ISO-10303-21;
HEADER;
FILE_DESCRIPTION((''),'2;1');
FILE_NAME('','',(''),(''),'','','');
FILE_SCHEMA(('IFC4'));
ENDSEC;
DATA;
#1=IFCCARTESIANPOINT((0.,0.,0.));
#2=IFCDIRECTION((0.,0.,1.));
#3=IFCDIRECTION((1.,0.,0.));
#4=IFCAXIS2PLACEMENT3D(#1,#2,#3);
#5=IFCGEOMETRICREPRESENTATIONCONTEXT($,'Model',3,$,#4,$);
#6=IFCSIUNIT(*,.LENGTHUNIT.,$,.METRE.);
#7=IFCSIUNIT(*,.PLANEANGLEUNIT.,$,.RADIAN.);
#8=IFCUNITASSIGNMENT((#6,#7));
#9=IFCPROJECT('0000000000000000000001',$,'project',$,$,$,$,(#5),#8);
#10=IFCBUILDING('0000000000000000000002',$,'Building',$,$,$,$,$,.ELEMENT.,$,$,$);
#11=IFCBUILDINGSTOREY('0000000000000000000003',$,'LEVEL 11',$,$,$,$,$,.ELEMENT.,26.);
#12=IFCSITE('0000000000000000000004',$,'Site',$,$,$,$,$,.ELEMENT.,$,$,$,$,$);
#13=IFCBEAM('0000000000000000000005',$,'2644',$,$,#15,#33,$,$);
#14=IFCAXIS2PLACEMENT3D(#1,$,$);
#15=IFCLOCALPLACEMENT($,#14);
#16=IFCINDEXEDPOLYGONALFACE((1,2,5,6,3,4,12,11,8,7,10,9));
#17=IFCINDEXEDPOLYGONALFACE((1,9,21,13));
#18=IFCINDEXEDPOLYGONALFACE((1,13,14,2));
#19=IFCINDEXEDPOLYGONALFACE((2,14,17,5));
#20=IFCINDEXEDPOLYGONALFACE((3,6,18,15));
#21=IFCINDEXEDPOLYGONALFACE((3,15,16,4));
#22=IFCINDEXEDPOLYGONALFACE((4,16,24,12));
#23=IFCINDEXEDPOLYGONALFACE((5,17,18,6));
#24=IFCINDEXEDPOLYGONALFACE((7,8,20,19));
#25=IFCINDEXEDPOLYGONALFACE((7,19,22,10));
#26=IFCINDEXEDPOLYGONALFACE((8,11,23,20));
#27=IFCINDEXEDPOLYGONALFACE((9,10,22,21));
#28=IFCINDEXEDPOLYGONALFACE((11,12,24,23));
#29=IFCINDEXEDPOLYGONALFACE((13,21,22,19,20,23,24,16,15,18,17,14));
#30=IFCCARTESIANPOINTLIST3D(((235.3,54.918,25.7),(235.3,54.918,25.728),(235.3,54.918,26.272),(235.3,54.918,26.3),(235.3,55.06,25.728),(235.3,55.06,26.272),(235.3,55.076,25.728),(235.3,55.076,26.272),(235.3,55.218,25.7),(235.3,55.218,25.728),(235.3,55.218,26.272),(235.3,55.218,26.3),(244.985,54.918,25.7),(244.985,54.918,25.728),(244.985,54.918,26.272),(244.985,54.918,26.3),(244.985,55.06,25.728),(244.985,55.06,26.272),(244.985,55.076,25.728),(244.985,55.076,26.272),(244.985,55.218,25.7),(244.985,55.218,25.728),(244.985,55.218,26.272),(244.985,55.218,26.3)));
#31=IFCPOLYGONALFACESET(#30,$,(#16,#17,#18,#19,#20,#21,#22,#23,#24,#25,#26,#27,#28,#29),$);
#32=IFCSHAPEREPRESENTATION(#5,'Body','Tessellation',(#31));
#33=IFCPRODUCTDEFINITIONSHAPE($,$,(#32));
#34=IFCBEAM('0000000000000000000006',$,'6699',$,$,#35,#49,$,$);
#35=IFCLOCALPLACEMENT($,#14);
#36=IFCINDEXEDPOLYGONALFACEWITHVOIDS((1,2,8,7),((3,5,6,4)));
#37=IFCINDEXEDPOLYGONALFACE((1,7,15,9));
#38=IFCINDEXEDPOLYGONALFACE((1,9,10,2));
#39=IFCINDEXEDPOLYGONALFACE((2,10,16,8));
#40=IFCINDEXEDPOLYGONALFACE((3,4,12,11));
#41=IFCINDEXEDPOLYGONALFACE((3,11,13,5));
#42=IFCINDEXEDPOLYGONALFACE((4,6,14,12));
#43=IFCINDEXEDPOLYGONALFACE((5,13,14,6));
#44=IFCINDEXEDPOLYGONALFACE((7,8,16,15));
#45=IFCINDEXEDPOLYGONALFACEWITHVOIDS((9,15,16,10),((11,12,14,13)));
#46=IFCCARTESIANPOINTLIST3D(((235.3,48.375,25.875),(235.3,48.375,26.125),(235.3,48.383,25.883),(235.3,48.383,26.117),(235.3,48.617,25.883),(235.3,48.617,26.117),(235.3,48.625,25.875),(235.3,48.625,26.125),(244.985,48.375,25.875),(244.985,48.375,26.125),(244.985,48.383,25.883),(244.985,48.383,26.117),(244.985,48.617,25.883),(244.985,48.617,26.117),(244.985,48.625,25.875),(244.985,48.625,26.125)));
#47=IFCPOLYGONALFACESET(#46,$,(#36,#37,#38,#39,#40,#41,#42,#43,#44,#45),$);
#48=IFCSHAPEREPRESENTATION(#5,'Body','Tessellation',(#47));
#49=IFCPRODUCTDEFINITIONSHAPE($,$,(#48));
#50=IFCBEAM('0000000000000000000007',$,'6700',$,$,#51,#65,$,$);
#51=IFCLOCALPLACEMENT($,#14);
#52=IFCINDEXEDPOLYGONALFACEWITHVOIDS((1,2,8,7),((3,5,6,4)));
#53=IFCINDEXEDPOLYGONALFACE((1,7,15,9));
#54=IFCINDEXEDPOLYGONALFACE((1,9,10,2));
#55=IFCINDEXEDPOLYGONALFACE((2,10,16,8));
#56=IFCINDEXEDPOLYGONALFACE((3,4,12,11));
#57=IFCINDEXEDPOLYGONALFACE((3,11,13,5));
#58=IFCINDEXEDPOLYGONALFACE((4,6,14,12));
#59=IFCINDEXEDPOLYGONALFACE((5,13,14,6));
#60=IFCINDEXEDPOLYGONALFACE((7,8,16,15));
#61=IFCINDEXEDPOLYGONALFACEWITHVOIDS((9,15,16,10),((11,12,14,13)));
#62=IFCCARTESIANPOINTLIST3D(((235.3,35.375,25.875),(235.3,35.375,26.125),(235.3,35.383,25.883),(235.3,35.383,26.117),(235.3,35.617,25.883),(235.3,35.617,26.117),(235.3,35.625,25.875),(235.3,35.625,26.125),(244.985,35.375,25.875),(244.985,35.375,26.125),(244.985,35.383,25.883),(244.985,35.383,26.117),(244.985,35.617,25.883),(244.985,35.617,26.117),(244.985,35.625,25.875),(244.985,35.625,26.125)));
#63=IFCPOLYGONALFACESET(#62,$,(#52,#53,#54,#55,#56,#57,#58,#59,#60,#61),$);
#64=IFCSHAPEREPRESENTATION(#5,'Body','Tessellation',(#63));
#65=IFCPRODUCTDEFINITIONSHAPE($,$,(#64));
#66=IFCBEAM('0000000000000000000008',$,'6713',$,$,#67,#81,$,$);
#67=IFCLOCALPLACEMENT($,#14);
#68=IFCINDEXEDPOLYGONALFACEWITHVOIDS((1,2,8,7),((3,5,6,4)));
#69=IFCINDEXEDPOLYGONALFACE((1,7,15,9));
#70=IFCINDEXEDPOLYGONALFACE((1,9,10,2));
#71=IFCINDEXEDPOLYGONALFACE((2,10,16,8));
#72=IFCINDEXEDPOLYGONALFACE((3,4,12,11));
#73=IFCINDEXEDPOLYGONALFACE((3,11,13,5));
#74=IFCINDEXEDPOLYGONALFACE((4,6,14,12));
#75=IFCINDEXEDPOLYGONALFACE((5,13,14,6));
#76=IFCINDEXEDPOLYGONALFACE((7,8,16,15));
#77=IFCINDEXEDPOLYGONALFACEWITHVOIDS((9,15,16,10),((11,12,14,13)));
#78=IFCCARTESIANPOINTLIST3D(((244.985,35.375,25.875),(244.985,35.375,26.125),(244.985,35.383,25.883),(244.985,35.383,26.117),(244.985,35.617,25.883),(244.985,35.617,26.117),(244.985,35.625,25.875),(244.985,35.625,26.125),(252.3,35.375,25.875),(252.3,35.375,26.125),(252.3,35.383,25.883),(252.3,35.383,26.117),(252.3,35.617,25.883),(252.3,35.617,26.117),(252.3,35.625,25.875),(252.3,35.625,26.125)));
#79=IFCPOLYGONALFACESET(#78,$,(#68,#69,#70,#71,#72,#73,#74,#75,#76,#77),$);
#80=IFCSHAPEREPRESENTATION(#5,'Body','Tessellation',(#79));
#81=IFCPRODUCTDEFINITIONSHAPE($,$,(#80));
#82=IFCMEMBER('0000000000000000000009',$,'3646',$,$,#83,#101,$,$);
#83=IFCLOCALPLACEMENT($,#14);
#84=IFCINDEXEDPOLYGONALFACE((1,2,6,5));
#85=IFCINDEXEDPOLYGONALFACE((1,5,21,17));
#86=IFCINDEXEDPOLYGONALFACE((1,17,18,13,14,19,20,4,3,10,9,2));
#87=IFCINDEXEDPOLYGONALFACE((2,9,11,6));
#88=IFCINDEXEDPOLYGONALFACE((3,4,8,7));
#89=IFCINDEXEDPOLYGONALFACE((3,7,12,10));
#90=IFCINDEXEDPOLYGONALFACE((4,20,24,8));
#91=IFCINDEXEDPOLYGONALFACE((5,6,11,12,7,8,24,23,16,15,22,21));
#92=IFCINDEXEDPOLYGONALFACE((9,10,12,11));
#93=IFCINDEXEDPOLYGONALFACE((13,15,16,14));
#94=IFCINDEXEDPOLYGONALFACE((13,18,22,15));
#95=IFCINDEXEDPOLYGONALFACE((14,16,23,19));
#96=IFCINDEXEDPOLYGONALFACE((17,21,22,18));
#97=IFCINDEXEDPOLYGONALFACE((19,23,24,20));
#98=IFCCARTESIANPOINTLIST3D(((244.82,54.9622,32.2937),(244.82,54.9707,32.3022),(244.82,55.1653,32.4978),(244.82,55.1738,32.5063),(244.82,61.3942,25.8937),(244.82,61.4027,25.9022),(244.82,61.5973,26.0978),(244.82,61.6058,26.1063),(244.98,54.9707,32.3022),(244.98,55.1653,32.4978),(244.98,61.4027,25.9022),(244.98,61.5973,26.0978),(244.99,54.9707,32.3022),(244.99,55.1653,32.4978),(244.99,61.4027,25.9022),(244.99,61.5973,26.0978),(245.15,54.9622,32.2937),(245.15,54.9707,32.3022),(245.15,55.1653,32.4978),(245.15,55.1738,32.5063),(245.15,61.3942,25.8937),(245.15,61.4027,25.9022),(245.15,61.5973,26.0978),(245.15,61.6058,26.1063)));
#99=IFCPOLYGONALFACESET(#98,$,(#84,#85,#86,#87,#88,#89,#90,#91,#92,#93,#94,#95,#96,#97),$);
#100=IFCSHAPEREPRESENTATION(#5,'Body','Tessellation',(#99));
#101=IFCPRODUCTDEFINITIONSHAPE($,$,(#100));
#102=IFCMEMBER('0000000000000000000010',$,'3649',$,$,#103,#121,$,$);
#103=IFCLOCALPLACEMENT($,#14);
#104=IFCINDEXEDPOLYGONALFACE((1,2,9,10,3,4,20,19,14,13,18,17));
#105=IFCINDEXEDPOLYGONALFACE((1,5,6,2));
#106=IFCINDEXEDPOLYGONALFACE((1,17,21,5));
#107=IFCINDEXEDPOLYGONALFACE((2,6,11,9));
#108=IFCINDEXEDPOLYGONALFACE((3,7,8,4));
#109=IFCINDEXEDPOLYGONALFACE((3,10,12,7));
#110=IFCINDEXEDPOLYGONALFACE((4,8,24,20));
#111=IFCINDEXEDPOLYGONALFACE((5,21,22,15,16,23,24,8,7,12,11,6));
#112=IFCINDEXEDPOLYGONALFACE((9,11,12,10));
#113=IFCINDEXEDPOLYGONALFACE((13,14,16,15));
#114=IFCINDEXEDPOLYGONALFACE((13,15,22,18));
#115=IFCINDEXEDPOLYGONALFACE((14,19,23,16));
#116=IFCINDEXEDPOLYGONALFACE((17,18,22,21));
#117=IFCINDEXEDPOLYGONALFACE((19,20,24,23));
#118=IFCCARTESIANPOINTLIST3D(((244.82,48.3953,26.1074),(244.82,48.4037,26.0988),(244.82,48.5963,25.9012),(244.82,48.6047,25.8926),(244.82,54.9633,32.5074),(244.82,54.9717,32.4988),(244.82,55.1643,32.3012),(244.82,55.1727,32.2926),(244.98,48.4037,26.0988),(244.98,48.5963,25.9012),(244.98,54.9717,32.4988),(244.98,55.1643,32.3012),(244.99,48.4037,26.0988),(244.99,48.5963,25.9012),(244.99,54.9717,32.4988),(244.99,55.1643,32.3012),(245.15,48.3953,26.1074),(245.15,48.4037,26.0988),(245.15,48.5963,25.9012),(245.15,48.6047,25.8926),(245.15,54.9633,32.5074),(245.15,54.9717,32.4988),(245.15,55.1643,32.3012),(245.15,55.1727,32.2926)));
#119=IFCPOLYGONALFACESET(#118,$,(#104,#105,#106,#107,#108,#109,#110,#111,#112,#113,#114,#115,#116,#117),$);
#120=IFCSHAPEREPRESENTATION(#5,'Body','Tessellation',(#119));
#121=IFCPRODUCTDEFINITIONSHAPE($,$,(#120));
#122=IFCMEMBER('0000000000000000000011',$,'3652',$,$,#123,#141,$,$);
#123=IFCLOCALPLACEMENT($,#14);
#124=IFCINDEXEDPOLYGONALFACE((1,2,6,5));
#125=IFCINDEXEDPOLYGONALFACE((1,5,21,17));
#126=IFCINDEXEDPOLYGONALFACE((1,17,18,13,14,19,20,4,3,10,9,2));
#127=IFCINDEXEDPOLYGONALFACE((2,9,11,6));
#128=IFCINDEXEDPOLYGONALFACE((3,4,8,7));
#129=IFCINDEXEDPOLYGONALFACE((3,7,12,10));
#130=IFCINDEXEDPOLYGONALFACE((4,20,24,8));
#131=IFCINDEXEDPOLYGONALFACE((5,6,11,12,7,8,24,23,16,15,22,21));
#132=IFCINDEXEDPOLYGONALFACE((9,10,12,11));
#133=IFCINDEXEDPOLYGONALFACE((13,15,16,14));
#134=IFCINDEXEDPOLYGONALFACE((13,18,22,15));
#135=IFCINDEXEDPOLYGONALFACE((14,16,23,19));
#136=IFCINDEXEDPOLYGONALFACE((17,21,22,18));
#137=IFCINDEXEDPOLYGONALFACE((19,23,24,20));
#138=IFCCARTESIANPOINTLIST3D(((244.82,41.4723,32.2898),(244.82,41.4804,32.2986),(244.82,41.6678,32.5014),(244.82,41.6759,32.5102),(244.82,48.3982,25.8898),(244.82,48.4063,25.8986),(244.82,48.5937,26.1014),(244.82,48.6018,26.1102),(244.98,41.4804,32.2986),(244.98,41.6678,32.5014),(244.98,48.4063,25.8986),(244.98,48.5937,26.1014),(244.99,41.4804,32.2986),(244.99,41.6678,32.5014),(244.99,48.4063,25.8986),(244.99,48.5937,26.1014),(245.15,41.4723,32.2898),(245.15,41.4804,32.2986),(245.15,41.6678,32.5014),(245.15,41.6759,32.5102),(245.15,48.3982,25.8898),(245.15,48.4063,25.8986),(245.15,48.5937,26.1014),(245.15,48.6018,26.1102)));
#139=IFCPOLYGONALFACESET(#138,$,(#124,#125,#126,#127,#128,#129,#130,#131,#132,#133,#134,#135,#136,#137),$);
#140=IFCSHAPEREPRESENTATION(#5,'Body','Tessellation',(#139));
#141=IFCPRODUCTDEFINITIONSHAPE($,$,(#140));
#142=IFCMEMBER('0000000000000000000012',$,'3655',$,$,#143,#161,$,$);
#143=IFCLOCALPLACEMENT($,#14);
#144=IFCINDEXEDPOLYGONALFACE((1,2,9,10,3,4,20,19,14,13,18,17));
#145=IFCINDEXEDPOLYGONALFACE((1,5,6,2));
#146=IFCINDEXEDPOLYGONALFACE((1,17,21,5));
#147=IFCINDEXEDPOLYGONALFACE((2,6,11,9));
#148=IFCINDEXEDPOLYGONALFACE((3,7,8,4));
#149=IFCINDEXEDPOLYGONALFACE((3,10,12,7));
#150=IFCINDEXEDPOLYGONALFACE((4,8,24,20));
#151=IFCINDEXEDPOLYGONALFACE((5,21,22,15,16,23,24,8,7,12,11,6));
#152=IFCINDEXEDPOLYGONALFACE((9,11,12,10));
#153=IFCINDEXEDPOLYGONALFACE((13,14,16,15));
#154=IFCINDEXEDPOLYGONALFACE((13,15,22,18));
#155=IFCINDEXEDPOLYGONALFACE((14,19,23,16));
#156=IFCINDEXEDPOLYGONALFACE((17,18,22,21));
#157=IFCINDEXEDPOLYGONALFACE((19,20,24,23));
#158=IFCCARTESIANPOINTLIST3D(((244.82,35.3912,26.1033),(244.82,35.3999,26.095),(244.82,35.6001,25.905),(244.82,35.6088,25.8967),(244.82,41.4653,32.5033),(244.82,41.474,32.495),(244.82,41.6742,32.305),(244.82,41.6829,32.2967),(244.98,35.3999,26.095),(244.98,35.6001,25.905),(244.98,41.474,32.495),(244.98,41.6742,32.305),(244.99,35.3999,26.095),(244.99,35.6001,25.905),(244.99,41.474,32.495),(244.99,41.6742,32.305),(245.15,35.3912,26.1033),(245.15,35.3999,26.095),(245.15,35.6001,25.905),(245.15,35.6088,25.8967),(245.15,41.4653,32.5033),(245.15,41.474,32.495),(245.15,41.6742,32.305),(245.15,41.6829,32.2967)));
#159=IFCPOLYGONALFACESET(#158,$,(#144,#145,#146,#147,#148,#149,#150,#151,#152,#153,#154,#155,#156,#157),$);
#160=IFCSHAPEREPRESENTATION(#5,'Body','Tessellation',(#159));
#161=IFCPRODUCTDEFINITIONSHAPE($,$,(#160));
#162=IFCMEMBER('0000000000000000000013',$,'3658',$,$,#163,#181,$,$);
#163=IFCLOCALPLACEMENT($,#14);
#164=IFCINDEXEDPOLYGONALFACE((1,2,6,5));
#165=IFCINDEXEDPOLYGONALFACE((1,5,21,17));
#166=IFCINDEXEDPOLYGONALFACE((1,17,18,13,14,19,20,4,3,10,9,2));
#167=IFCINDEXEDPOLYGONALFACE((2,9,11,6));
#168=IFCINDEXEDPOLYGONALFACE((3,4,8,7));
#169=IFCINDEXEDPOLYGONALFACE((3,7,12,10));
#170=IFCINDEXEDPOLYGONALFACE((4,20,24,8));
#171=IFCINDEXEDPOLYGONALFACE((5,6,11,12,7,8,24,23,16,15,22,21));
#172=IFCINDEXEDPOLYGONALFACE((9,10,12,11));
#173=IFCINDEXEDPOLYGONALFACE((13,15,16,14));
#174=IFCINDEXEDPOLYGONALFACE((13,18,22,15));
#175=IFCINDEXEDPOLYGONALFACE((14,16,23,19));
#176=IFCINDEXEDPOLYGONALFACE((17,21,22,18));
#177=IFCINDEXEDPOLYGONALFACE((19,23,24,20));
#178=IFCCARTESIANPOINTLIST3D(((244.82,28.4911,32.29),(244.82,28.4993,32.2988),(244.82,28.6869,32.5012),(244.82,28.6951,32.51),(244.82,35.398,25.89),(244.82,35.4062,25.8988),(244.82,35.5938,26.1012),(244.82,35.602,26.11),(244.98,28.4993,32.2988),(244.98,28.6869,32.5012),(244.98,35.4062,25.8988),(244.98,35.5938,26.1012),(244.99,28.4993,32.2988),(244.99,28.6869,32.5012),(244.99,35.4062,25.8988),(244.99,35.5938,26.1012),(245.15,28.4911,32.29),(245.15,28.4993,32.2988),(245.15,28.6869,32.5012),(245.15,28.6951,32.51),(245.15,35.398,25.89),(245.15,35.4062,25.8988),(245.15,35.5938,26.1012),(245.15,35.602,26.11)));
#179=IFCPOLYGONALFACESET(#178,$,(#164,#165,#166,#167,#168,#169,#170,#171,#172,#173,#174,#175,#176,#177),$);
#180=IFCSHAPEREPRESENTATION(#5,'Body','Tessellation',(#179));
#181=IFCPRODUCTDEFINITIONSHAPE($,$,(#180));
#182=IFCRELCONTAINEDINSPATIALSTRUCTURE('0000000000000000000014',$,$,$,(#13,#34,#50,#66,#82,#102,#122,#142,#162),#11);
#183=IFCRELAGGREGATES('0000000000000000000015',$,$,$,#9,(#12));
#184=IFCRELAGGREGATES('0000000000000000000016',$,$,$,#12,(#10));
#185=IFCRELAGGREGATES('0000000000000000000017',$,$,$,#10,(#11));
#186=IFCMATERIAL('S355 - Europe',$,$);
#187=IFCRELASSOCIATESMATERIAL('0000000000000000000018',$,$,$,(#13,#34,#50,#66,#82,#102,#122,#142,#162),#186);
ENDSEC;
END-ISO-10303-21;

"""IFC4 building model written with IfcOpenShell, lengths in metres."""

from ifc_helpers import new_model, si_unit, frame, origin_with_axes, origin_2d_with_axis, place, context, project, spatial, hollow_rectangle, i_section, extrude, material, material_profile, profile_set, profile_usage, element, save


model = new_model("IFC4")

# Units and contexts
model_context = context("Model", 3, world=origin_with_axes())
ifc_project = project(units=[si_unit("LENGTHUNIT", "METRE"), si_unit("PLANEANGLEUNIT", "RADIAN")], contexts=[model_context])

# Site, building, storey
site = spatial("IfcSite", under=ifc_project, Name="Site", CompositionType="ELEMENT")
building = spatial("IfcBuilding", under=site, Name="Building", CompositionType="ELEMENT")
storey = spatial("IfcBuildingStorey", under=building, Name="LEVEL 11", CompositionType="ELEMENT", Elevation=26.0)

# Shared definitions
ifc_material = material(Name="S355 - Europe")

# Beams
ifc_material_profile_1 = material_profile(ifc_material, i_section(OverallWidth=0.3, OverallDepth=0.6, WebThickness=0.016, FlangeThickness=0.028, at=origin_2d_with_axis()))
ifc_profile_set_1 = profile_set([ifc_material_profile_1])
ifc_profile_usage_1 = profile_usage(ifc_profile_set_1, cardinal=10)
beam_1_placement = place(None, frame((244.985, 55.068, 26.0), z_axis=(-1.0, 0.0, 0.0), x_axis=(0.0, -1.0, 0.0)))
element("IfcBeam", 1, at=beam_1_placement, inside=storey, material=ifc_profile_usage_1, Name="2644", context=model_context, shape_type="SweptSolid", body=[
    extrude(i_section(OverallWidth=0.3, OverallDepth=0.6, WebThickness=0.016, FlangeThickness=0.028, at=origin_2d_with_axis()), origin_with_axes(), (0.0, 0.0, 1.0), 9.685),
])
ifc_material_profile_2 = material_profile(ifc_material, hollow_rectangle(XDim=0.25, YDim=0.25, WallThickness=0.008, at=origin_2d_with_axis()))
ifc_profile_set_2 = profile_set([ifc_material_profile_2])
ifc_profile_usage_2 = profile_usage(ifc_profile_set_2, cardinal=10)
beam_2_placement = place(None, frame((244.985, 48.5, 26.0), z_axis=(-1.0, 0.0, 0.0), x_axis=(0.0, -1.0, 0.0)))
element("IfcBeam", 2, at=beam_2_placement, inside=storey, material=ifc_profile_usage_2, Name="6699", context=model_context, shape_type="SweptSolid", body=[
    extrude(hollow_rectangle(XDim=0.25, YDim=0.25, WallThickness=0.008, at=origin_2d_with_axis()), origin_with_axes(), (0.0, 0.0, 1.0), 9.685),
])
ifc_material_profile_3 = material_profile(ifc_material, hollow_rectangle(XDim=0.25, YDim=0.25, WallThickness=0.008, at=origin_2d_with_axis()))
ifc_profile_set_3 = profile_set([ifc_material_profile_3])
ifc_profile_usage_3 = profile_usage(ifc_profile_set_3, cardinal=10)
beam_3_placement = place(None, frame((244.985, 35.5, 26.0), z_axis=(-1.0, 0.0, 0.0), x_axis=(0.0, -1.0, 0.0)))
element("IfcBeam", 3, at=beam_3_placement, inside=storey, material=ifc_profile_usage_3, Name="6700", context=model_context, shape_type="SweptSolid", body=[
    extrude(hollow_rectangle(XDim=0.25, YDim=0.25, WallThickness=0.008, at=origin_2d_with_axis()), origin_with_axes(), (0.0, 0.0, 1.0), 9.685),
])
ifc_material_profile_4 = material_profile(ifc_material, hollow_rectangle(XDim=0.25, YDim=0.25, WallThickness=0.008, at=origin_2d_with_axis()))
ifc_profile_set_4 = profile_set([ifc_material_profile_4])
ifc_profile_usage_4 = profile_usage(ifc_profile_set_4, cardinal=10)
beam_4_placement = place(None, frame((252.3, 35.5, 26.0), z_axis=(-1.0, 0.0, 0.0), x_axis=(0.0, -1.0, 0.0)))
element("IfcBeam", 4, at=beam_4_placement, inside=storey, material=ifc_profile_usage_4, Name="6713", context=model_context, shape_type="SweptSolid", body=[
    extrude(hollow_rectangle(XDim=0.25, YDim=0.25, WallThickness=0.008, at=origin_2d_with_axis()), origin_with_axes(), (0.0, 0.0, 1.0), 7.315),
])

# Members
ifc_material_profile_5 = material_profile(ifc_material, i_section(OverallWidth=0.33, OverallDepth=0.3, WebThickness=0.01, FlangeThickness=0.012, at=origin_2d_with_axis()))
ifc_profile_set_5 = profile_set([ifc_material_profile_5])
ifc_profile_usage_5 = profile_usage(ifc_profile_set_5, cardinal=10)
member_1_placement = place(None, frame((244.985, 55.068, 32.4), z_axis=(0.0, 0.708868, -0.705341), x_axis=(-1.0, 0.0, 0.0)))
element("IfcMember", 5, at=member_1_placement, inside=storey, material=ifc_profile_usage_5, Name="3646", context=model_context, shape_type="SweptSolid", body=[
    extrude(i_section(OverallWidth=0.33, OverallDepth=0.3, WebThickness=0.01, FlangeThickness=0.012, at=origin_2d_with_axis()), origin_with_axes(), (0.0, 0.0, 1.0), 9.0736),
])
ifc_material_profile_6 = material_profile(ifc_material, i_section(OverallWidth=0.33, OverallDepth=0.3, WebThickness=0.01, FlangeThickness=0.012, at=origin_2d_with_axis()))
ifc_profile_set_6 = profile_set([ifc_material_profile_6])
ifc_profile_usage_6 = profile_usage(ifc_profile_set_6, cardinal=10)
member_2_placement = place(None, frame((244.985, 48.5, 26.0), z_axis=(0.0, 0.716207, 0.697888), x_axis=(-1.0, 0.0, 0.0)))
element("IfcMember", 6, at=member_2_placement, inside=storey, material=ifc_profile_usage_6, Name="3649", context=model_context, shape_type="SweptSolid", body=[
    extrude(i_section(OverallWidth=0.33, OverallDepth=0.3, WebThickness=0.01, FlangeThickness=0.012, at=origin_2d_with_axis()), origin_with_axes(), (0.0, 0.0, 1.0), 9.1705),
])
ifc_material_profile_7 = material_profile(ifc_material, i_section(OverallWidth=0.33, OverallDepth=0.3, WebThickness=0.01, FlangeThickness=0.012, at=origin_2d_with_axis()))
ifc_profile_set_7 = profile_set([ifc_material_profile_7])
ifc_profile_usage_7 = profile_usage(ifc_profile_set_7, cardinal=10)
member_3_placement = place(None, frame((244.985, 41.5741, 32.4), z_axis=(0.0, 0.734441, -0.678673), x_axis=(-1.0, 0.0, 0.0)))
element("IfcMember", 7, at=member_3_placement, inside=storey, material=ifc_profile_usage_7, Name="3652", context=model_context, shape_type="SweptSolid", body=[
    extrude(i_section(OverallWidth=0.33, OverallDepth=0.3, WebThickness=0.01, FlangeThickness=0.012, at=origin_2d_with_axis()), origin_with_axes(), (0.0, 0.0, 1.0), 9.4302),
])
ifc_material_profile_8 = material_profile(ifc_material, i_section(OverallWidth=0.33, OverallDepth=0.3, WebThickness=0.01, FlangeThickness=0.012, at=origin_2d_with_axis()))
ifc_profile_set_8 = profile_set([ifc_material_profile_8])
ifc_profile_usage_8 = profile_usage(ifc_profile_set_8, cardinal=10)
member_4_placement = place(None, frame((244.985, 35.5, 26.0), z_axis=(0.0, 0.688398, 0.725333), x_axis=(-1.0, 0.0, 0.0)))
element("IfcMember", 8, at=member_4_placement, inside=storey, material=ifc_profile_usage_8, Name="3655", context=model_context, shape_type="SweptSolid", body=[
    extrude(i_section(OverallWidth=0.33, OverallDepth=0.3, WebThickness=0.01, FlangeThickness=0.012, at=origin_2d_with_axis()), origin_with_axes(), (0.0, 0.0, 1.0), 8.8235),
])
ifc_material_profile_9 = material_profile(ifc_material, i_section(OverallWidth=0.33, OverallDepth=0.3, WebThickness=0.01, FlangeThickness=0.012, at=origin_2d_with_axis()))
ifc_profile_set_9 = profile_set([ifc_material_profile_9])
ifc_profile_usage_9 = profile_usage(ifc_profile_set_9, cardinal=10)
member_5_placement = place(None, frame((244.985, 28.5931, 32.4), z_axis=(0.0, 0.733511, -0.679678), x_axis=(-1.0, 0.0, 0.0)))
element("IfcMember", 9, at=member_5_placement, inside=storey, material=ifc_profile_usage_9, Name="3658", context=model_context, shape_type="SweptSolid", body=[
    extrude(i_section(OverallWidth=0.33, OverallDepth=0.3, WebThickness=0.01, FlangeThickness=0.012, at=origin_2d_with_axis()), origin_with_axes(), (0.0, 0.0, 1.0), 9.4162),
])

save(model, "model.ifc")
